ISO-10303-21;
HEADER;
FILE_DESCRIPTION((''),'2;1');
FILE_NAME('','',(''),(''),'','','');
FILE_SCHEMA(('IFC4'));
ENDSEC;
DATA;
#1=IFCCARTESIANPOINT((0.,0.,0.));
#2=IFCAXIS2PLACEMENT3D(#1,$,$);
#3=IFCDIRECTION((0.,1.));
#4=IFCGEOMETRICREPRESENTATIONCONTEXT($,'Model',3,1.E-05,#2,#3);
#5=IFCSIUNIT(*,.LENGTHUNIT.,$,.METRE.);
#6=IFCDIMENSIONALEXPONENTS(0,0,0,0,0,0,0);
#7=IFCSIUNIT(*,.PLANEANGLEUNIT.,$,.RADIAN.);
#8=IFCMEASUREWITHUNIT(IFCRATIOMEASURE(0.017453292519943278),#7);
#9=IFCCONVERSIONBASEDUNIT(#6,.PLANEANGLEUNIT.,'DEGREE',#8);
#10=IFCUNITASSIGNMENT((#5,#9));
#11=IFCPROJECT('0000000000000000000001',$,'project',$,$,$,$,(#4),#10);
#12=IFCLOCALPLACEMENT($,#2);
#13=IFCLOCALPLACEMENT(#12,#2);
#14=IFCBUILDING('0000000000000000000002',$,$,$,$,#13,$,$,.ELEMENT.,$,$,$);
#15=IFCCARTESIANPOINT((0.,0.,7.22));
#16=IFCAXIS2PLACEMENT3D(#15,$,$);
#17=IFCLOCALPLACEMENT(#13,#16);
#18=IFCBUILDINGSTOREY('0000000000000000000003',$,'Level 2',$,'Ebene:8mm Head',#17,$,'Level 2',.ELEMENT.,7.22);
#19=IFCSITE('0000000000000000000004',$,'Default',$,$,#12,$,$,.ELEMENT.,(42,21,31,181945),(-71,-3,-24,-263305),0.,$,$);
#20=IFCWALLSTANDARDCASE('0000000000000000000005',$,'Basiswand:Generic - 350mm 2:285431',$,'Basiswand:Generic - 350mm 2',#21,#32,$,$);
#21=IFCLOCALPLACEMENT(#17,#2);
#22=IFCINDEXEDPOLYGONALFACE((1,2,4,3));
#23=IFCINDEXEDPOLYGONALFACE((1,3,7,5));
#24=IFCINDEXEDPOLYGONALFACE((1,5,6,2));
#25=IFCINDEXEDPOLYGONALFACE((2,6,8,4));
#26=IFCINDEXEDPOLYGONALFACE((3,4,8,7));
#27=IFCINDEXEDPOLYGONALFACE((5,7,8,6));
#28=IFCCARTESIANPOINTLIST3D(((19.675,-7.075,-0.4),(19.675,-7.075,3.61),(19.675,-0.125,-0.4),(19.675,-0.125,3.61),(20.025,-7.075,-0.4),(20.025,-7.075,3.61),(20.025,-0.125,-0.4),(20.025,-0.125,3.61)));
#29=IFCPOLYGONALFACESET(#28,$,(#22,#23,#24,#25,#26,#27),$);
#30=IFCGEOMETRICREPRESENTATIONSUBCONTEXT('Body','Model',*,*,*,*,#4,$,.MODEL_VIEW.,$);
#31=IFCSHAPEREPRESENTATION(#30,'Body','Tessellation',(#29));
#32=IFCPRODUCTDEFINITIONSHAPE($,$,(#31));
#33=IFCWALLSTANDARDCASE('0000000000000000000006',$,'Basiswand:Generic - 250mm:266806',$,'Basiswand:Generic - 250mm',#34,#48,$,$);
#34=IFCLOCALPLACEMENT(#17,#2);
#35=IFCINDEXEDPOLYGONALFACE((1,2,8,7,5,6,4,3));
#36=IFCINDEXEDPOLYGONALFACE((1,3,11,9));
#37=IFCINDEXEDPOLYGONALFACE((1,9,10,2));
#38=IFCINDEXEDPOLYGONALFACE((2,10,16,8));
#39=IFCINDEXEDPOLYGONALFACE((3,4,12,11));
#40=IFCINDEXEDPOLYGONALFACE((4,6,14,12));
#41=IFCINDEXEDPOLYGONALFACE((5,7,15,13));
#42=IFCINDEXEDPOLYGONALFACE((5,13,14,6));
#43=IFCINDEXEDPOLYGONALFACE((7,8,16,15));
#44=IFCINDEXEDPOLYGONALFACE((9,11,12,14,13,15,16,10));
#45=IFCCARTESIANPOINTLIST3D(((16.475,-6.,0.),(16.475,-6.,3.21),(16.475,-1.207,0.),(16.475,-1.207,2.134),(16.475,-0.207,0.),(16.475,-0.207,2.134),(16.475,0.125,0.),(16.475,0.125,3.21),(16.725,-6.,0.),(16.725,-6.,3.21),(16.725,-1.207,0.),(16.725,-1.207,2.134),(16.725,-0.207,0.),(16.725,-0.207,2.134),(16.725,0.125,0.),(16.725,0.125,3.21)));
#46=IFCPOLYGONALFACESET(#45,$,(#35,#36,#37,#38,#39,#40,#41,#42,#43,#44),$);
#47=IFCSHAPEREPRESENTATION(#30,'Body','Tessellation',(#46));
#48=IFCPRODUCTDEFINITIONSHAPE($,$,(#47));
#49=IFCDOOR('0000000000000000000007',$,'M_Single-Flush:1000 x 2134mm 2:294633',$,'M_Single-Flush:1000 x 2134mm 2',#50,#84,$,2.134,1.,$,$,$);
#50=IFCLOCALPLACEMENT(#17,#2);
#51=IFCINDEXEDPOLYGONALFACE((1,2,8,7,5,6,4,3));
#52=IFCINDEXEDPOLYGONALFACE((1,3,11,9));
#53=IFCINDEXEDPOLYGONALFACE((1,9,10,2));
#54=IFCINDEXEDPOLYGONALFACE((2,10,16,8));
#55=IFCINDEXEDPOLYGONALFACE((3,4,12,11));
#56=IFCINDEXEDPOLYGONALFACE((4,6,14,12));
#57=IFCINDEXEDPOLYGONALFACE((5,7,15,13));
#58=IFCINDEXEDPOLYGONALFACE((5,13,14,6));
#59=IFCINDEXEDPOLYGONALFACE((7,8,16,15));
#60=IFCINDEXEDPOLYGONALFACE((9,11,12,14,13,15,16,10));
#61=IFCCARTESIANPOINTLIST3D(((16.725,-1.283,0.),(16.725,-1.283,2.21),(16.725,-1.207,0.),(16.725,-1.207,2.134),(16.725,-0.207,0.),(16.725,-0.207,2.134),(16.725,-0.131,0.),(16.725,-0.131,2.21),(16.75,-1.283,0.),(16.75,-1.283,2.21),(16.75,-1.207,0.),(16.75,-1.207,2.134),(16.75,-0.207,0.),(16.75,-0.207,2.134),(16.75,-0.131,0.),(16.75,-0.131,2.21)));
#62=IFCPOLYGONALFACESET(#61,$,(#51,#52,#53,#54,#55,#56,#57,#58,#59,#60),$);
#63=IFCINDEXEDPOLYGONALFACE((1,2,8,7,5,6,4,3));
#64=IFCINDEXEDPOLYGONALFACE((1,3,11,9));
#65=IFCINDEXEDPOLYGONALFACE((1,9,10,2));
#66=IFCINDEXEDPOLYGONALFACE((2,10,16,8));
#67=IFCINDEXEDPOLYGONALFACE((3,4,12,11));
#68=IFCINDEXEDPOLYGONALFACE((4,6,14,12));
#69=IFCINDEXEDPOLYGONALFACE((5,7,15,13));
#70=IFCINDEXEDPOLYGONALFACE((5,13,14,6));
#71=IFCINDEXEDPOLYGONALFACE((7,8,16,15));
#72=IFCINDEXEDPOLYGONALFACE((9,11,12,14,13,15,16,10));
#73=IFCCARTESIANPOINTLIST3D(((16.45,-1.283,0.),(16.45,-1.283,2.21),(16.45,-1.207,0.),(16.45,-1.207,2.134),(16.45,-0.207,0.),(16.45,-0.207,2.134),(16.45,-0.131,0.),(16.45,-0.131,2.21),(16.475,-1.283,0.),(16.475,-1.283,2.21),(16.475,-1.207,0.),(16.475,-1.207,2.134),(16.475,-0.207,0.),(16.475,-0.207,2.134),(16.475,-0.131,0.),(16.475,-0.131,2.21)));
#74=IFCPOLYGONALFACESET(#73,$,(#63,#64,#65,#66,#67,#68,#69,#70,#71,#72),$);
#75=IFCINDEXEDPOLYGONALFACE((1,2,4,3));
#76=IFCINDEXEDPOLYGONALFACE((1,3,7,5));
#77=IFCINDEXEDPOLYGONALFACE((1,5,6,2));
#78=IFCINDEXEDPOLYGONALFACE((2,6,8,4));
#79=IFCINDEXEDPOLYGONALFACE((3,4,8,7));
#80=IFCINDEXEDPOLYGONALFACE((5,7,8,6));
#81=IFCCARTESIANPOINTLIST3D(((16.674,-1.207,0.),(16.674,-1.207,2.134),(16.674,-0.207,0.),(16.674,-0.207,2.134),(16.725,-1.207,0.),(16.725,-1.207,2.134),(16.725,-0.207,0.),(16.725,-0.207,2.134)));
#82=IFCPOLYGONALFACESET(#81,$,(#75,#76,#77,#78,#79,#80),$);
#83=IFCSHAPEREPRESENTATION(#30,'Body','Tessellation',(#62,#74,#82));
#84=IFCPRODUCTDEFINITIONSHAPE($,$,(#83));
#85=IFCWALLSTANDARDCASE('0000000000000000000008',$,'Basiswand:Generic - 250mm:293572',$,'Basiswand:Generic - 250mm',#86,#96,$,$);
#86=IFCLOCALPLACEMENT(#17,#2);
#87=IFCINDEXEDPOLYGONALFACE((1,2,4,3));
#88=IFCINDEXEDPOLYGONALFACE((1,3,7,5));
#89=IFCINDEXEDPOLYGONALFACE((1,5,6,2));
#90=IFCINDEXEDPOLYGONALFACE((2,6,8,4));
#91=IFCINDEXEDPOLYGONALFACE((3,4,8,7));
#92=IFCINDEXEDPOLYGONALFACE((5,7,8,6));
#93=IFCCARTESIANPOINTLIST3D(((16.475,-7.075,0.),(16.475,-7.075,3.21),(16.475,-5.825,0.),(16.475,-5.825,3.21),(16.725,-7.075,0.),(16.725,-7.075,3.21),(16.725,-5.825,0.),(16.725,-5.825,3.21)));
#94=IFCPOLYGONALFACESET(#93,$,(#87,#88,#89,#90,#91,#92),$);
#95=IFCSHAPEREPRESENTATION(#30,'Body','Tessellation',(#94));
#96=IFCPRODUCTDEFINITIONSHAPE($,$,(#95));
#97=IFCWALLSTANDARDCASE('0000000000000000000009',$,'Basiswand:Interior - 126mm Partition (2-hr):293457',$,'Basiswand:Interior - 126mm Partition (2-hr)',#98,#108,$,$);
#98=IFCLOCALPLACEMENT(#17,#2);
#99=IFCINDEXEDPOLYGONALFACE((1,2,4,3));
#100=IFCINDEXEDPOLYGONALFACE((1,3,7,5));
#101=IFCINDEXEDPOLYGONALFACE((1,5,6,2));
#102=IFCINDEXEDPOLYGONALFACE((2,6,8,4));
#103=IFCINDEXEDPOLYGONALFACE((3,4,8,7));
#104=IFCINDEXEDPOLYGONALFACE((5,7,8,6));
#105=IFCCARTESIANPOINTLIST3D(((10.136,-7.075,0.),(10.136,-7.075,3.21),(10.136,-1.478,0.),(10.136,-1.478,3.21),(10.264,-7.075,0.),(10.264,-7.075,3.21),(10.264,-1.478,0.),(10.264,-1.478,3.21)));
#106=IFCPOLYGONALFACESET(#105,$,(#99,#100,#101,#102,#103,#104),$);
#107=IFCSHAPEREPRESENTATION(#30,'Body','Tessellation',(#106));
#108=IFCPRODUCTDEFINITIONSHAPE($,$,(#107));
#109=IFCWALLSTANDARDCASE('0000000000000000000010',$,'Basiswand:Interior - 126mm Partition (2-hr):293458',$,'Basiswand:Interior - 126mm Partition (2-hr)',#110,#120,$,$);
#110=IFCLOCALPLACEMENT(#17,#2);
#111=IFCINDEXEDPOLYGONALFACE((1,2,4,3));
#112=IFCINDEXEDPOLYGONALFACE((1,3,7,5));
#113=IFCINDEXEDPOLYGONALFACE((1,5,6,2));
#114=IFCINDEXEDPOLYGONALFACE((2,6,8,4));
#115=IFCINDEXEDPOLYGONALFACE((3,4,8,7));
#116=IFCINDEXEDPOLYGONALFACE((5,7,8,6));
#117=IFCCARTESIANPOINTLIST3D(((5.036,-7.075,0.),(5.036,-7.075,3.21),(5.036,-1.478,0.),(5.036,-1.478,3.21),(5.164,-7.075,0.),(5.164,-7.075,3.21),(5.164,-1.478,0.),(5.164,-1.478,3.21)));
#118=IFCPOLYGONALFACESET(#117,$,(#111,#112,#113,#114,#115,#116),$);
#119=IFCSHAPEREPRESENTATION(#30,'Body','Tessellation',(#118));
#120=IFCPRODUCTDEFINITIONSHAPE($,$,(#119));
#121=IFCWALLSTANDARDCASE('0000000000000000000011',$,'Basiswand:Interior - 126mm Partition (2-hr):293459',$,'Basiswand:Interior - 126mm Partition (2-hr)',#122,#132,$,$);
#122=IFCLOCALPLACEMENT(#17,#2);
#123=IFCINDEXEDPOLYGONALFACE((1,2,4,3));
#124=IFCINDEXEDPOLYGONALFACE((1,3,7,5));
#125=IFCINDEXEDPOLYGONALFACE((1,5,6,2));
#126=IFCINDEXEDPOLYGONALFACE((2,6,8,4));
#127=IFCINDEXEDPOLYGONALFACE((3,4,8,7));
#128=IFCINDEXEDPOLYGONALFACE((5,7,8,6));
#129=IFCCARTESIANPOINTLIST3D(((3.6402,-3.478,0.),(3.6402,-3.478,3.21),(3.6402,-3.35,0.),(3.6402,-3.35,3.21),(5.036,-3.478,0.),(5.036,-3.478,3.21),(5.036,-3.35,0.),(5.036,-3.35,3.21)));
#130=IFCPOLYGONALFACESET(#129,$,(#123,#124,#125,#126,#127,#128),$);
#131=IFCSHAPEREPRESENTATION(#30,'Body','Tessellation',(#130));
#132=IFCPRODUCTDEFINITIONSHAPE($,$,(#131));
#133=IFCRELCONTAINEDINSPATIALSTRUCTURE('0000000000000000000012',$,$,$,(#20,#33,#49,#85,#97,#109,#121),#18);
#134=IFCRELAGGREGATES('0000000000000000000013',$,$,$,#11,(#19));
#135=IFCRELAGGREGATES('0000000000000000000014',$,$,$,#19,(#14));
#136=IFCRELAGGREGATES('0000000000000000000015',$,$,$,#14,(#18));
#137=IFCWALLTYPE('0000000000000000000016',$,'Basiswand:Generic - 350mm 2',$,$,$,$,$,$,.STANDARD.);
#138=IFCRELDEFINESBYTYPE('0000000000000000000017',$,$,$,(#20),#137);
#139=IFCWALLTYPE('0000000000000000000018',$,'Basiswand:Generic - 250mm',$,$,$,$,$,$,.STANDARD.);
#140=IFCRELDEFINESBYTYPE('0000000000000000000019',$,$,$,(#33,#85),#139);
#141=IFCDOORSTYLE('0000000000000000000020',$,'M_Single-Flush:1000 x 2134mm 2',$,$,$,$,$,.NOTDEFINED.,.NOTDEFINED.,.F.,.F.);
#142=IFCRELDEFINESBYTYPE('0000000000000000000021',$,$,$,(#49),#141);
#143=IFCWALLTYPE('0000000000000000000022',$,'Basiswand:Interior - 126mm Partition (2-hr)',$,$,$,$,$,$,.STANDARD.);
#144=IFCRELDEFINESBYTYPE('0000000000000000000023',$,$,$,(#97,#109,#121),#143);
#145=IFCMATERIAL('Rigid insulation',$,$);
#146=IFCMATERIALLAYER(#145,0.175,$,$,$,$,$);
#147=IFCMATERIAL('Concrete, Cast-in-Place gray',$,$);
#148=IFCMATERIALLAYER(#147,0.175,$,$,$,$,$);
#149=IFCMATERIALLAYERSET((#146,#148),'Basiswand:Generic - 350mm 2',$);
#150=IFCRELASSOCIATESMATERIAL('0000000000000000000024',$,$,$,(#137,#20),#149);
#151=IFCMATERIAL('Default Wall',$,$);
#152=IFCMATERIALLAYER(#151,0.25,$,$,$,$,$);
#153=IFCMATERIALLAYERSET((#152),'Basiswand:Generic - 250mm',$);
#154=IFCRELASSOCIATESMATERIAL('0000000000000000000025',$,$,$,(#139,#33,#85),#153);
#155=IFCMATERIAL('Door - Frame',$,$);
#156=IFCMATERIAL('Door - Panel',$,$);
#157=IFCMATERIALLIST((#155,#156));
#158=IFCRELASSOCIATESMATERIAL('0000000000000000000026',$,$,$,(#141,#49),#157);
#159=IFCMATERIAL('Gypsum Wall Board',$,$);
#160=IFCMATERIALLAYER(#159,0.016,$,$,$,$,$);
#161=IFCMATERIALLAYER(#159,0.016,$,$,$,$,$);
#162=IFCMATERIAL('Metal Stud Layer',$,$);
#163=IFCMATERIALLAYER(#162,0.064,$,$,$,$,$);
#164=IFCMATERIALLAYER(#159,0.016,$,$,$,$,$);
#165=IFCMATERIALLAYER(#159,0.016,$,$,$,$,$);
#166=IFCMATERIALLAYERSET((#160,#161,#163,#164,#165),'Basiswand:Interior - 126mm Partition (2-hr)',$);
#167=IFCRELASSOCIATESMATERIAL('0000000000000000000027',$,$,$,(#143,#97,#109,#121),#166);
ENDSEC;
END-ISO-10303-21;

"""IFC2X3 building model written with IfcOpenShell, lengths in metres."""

from ifc_helpers import new_model, entity, si_unit, converted_unit, direction, frame, frame_2d, origin, place, context, subcontext, project, spatial, polyline, rectangle, outline, extrude, clip, bounded_halfspace, source, transform, mapped, material, material_list, layer, layer_set, layer_usage, type_object, type_shapes, element, fill, save


model = new_model("IFC2X3")

# Units and contexts
model_context = context("Model", 3, precision=1e-05, world=origin(), true_north=direction((0.0, 1.0)))
body_context = subcontext(model_context, "Body", "Model", "MODEL_VIEW")
ifc_project = project(units=[si_unit("LENGTHUNIT", "METRE"), converted_unit("PLANEANGLEUNIT", "DEGREE", entity("IfcRatioMeasure", 0.017453292519943278), si_unit("PLANEANGLEUNIT", "RADIAN"), dimensions=[0, 0, 0, 0, 0, 0, 0])], contexts=[model_context])

# Site, building, storey
site_placement = place(None, origin())
site = spatial("IfcSite", under=ifc_project, at=site_placement, Name="Default", CompositionType="ELEMENT", RefLatitude=(42, 21, 31, 181945), RefLongitude=(-71, -3, -24, -263305), RefElevation=0.0)
building_placement = place(site_placement, origin())
building = spatial("IfcBuilding", under=site, at=building_placement, CompositionType="ELEMENT")
storey_placement = place(building_placement, frame((0.0, 0.0, 7.22)))
storey = spatial("IfcBuildingStorey", under=building, at=storey_placement, Name="Level 2", ObjectType="Ebene:8mm Head", LongName="Level 2", CompositionType="ELEMENT", Elevation=7.22)

# Wall
ifc_material_1 = material(Name="Rigid insulation")
ifc_layer_1 = layer(ifc_material_1, 0.175)
ifc_material_2 = material(Name="Concrete, Cast-in-Place gray")
ifc_layer_2 = layer(ifc_material_2, 0.175)
ifc_layer_set_1 = layer_set([ifc_layer_1, ifc_layer_2], Name="Basiswand:Generic - 350mm 2")
ifc_layer_usage_1 = layer_usage(ifc_layer_set_1, "AXIS2", "NEGATIVE", 0.175)
wall_type_1 = type_object("IfcWallType", Name="Basiswand:Generic - 350mm 2", PredefinedType="STANDARD", material=ifc_layer_set_1)
wall_1_placement = place(storey_placement, frame((19.85, -7.075, -0.4), z_axis=(0.0, 0.0, 1.0), x_axis=(0.0, 1.0, 0.0)))
element("IfcWallStandardCase", 1, at=wall_1_placement, inside=storey, type_object=wall_type_1, material=ifc_layer_usage_1, Name="Basiswand:Generic - 350mm 2:285431", ObjectType="Basiswand:Generic - 350mm 2", context=body_context, shape_type="SweptSolid", body=[
    extrude(rectangle(XDim=6.95, YDim=0.35, at=frame_2d((3.475, 0.0), x_axis=(-1.0, 0.0))), origin(), (0.0, 0.0, 1.0), 4.01),
])

# Wall, opening, door
ifc_material_3 = material(Name="Default Wall")
ifc_layer_3 = layer(ifc_material_3, 0.25)
ifc_layer_set_2 = layer_set([ifc_layer_3], Name="Basiswand:Generic - 250mm")
ifc_layer_usage_2 = layer_usage(ifc_layer_set_2, "AXIS2", "NEGATIVE", 0.125)
wall_type_2 = type_object("IfcWallType", Name="Basiswand:Generic - 250mm", PredefinedType="STANDARD", material=ifc_layer_set_2)
wall_2_placement = place(storey_placement, frame((16.6, -6.0, 0.0), z_axis=(0.0, 0.0, 1.0), x_axis=(0.0, 1.0, 0.0)))
wall_2 = element("IfcWallStandardCase", 2, at=wall_2_placement, inside=storey, type_object=wall_type_2, material=ifc_layer_usage_2, Name="Basiswand:Generic - 250mm:266806", ObjectType="Basiswand:Generic - 250mm", context=body_context, shape_type="SweptSolid", body=[
    extrude(rectangle(XDim=6.125, YDim=0.25, at=frame_2d((3.0625, 0.0), x_axis=(-1.0, 0.0))), origin(), (0.0, 0.0, 1.0), 3.21),
])
opening_1_placement = place(wall_2_placement, frame((5.793, 0.125, 0.0)))
opening_1 = element("IfcOpeningElement", 3, at=opening_1_placement, cuts=wall_2, ObjectType="Opening", context=body_context, shape_type="SweptSolid", body=[
    extrude(rectangle(XDim=1.0, YDim=2.134, at=frame_2d((1.067, 0.5), x_axis=(0.0, -1.0))), frame((0.0, 0.0, 0.0), z_axis=(0.0, -1.0, 0.0), x_axis=(0.0, 0.0, 1.0)), (0.0, 0.0, 1.0), 0.25),
])
ifc_material_4 = material(Name="Door - Frame")
ifc_material_5 = material(Name="Door - Panel")
ifc_material_list = material_list([ifc_material_4, ifc_material_5])
door_style_1 = type_object("IfcDoorStyle", Name="M_Single-Flush:1000 x 2134mm 2", ConstructionType="NOTDEFINED", OperationType="NOTDEFINED", ParameterTakesPrecedence=False, Sizeable=False, material=ifc_material_list)
shared_shape_1 = source(origin(), body_context, "Body", "SweptSolid", [
    extrude(outline(polyline([(-0.576, -1.124), (0.576, -1.124), (0.576, 1.086), (0.5, 1.086), (0.5, -1.048), (-0.5, -1.048), (-0.5, 1.086), (-0.576, 1.086), (-0.576, -1.124)])), frame((0.5, 0.275, 1.086), z_axis=(0.0, -1.0, 0.0), x_axis=(-1.0, 0.0, 0.0)), (0.0, 0.0, 1.0), 0.025),
    extrude(outline(polyline([(-1.124, -0.576), (1.086, -0.576), (1.086, -0.5), (-1.048, -0.5), (-1.048, 0.5), (1.086, 0.5), (1.086, 0.576), (-1.124, 0.576), (-1.124, -0.576)])), frame((0.5, 0.0, 1.086), z_axis=(0.0, -1.0, 0.0), x_axis=(0.0, 0.0, -1.0)), (0.0, 0.0, 1.0), 0.025),
    extrude(rectangle(XDim=1.0, YDim=0.051, at=frame_2d((0.0, 0.0), x_axis=(1.0, 0.0))), frame((0.5, 0.2245, 0.0)), (0.0, 0.0, 1.0), 2.134),
])
type_shapes(door_style_1, [shared_shape_1])
door_1_placement = place(opening_1_placement, frame((0.0, 0.0, 0.0), z_axis=(0.0, 0.0, 1.0), x_axis=(-1.0, 0.0, 0.0)))
door_1 = element("IfcDoor", 4, at=door_1_placement, inside=storey, type_object=door_style_1, material=ifc_material_list, Name="M_Single-Flush:1000 x 2134mm 2:294633", ObjectType="M_Single-Flush:1000 x 2134mm 2", OverallHeight=2.134, OverallWidth=1.0, context=body_context, shape_type="MappedRepresentation", body=[
    mapped(shared_shape_1, transform((0.0, 0.0, 0.0), scale=1.0)),
])
fill(opening_1, door_1)

# Walls
wall_3_placement = place(storey_placement, frame((16.6, -5.825, 0.0), z_axis=(0.0, 0.0, 1.0), x_axis=(0.0, -1.0, 0.0)))
element("IfcWallStandardCase", 5, at=wall_3_placement, inside=storey, type_object=wall_type_2, material=ifc_layer_usage_2, Name="Basiswand:Generic - 250mm:293572", ObjectType="Basiswand:Generic - 250mm", context=body_context, shape_type="SweptSolid", body=[
    extrude(rectangle(XDim=1.25, YDim=0.25, at=frame_2d((0.625, 0.0), x_axis=(-1.0, 0.0))), origin(), (0.0, 0.0, 1.0), 3.21),
])
ifc_material_6 = material(Name="Gypsum Wall Board")
ifc_layer_4 = layer(ifc_material_6, 0.016)
ifc_layer_5 = layer(ifc_material_6, 0.016)
ifc_material_7 = material(Name="Metal Stud Layer")
ifc_layer_6 = layer(ifc_material_7, 0.064)
ifc_layer_7 = layer(ifc_material_6, 0.016)
ifc_layer_8 = layer(ifc_material_6, 0.016)
ifc_layer_set_3 = layer_set([ifc_layer_4, ifc_layer_5, ifc_layer_6, ifc_layer_7, ifc_layer_8], Name="Basiswand:Interior - 126mm Partition (2-hr)")
ifc_layer_usage_3 = layer_usage(ifc_layer_set_3, "AXIS2", "NEGATIVE", 0.064)
wall_type_3 = type_object("IfcWallType", Name="Basiswand:Interior - 126mm Partition (2-hr)", PredefinedType="STANDARD", material=ifc_layer_set_3)
wall_4_placement = place(storey_placement, frame((10.2, -7.075, 0.0), z_axis=(0.0, 0.0, 1.0), x_axis=(0.0, 1.0, 0.0)))
element("IfcWallStandardCase", 6, at=wall_4_placement, inside=storey, type_object=wall_type_3, material=ifc_layer_usage_3, Name="Basiswand:Interior - 126mm Partition (2-hr):293457", ObjectType="Basiswand:Interior - 126mm Partition (2-hr)", context=body_context, shape_type="Clipping", body=[
    clip(extrude(rectangle(XDim=5.597, YDim=0.128, at=frame_2d((2.7985, 0.0), x_axis=(-1.0, 0.0))), origin(), (0.0, 0.0, 1.0), 3.21), bounded_halfspace(frame((0.0, -0.064, 3.21), z_axis=(0.0, 0.0, -1.0), x_axis=(1.0, 0.0, 0.0)), True, frame((0.0, -0.064, 3.21)), polyline([(0.0, 0.0), (3.597, 0.0), (3.725, 0.0), (5.597, 0.0), (5.597, 0.128), (3.725, 0.128), (3.597, 0.128), (0.0, 0.128), (0.0, 0.0)]))),
])
wall_5_placement = place(storey_placement, frame((5.1, -7.075, 0.0), z_axis=(0.0, 0.0, 1.0), x_axis=(0.0, 1.0, 0.0)))
element("IfcWallStandardCase", 7, at=wall_5_placement, inside=storey, type_object=wall_type_3, material=ifc_layer_usage_3, Name="Basiswand:Interior - 126mm Partition (2-hr):293458", ObjectType="Basiswand:Interior - 126mm Partition (2-hr)", context=body_context, shape_type="Clipping", body=[
    clip(extrude(rectangle(XDim=5.597, YDim=0.128, at=frame_2d((2.7985, 0.0), x_axis=(-1.0, 0.0))), origin(), (0.0, 0.0, 1.0), 3.21), bounded_halfspace(frame((0.0, -0.064, 3.21), z_axis=(0.0, 0.0, -1.0), x_axis=(1.0, 0.0, 0.0)), True, frame((0.0, -0.064, 3.21)), polyline([(0.0, 0.0), (3.597, 0.0), (3.725, 0.0), (5.597, 0.0), (5.597, 0.128), (3.725, 0.128), (3.597, 0.128), (0.0, 0.128), (0.0, 0.0)]))),
])
wall_6_placement = place(storey_placement, frame((3.6402, -3.414, 0.0)))
element("IfcWallStandardCase", 8, at=wall_6_placement, inside=storey, type_object=wall_type_3, material=ifc_layer_usage_3, Name="Basiswand:Interior - 126mm Partition (2-hr):293459", ObjectType="Basiswand:Interior - 126mm Partition (2-hr)", context=body_context, shape_type="Clipping", body=[
    clip(extrude(rectangle(XDim=1.3958, YDim=0.128, at=frame_2d((0.6979, 0.0), x_axis=(-1.0, 0.0))), origin(), (0.0, 0.0, 1.0), 3.21), bounded_halfspace(frame((0.0, -0.064, 3.21), z_axis=(0.0, 0.0, -1.0), x_axis=(0.0, 1.0, 0.0)), True, frame((0.0, -0.064, 3.21)), polyline([(0.0, 0.0), (1.3958, 0.0), (1.3958, 0.128), (0.3238, 0.128), (0.1958, 0.128), (0.0, 0.128), (0.0, 0.0)]))),
])

save(model, "model.ifc")
